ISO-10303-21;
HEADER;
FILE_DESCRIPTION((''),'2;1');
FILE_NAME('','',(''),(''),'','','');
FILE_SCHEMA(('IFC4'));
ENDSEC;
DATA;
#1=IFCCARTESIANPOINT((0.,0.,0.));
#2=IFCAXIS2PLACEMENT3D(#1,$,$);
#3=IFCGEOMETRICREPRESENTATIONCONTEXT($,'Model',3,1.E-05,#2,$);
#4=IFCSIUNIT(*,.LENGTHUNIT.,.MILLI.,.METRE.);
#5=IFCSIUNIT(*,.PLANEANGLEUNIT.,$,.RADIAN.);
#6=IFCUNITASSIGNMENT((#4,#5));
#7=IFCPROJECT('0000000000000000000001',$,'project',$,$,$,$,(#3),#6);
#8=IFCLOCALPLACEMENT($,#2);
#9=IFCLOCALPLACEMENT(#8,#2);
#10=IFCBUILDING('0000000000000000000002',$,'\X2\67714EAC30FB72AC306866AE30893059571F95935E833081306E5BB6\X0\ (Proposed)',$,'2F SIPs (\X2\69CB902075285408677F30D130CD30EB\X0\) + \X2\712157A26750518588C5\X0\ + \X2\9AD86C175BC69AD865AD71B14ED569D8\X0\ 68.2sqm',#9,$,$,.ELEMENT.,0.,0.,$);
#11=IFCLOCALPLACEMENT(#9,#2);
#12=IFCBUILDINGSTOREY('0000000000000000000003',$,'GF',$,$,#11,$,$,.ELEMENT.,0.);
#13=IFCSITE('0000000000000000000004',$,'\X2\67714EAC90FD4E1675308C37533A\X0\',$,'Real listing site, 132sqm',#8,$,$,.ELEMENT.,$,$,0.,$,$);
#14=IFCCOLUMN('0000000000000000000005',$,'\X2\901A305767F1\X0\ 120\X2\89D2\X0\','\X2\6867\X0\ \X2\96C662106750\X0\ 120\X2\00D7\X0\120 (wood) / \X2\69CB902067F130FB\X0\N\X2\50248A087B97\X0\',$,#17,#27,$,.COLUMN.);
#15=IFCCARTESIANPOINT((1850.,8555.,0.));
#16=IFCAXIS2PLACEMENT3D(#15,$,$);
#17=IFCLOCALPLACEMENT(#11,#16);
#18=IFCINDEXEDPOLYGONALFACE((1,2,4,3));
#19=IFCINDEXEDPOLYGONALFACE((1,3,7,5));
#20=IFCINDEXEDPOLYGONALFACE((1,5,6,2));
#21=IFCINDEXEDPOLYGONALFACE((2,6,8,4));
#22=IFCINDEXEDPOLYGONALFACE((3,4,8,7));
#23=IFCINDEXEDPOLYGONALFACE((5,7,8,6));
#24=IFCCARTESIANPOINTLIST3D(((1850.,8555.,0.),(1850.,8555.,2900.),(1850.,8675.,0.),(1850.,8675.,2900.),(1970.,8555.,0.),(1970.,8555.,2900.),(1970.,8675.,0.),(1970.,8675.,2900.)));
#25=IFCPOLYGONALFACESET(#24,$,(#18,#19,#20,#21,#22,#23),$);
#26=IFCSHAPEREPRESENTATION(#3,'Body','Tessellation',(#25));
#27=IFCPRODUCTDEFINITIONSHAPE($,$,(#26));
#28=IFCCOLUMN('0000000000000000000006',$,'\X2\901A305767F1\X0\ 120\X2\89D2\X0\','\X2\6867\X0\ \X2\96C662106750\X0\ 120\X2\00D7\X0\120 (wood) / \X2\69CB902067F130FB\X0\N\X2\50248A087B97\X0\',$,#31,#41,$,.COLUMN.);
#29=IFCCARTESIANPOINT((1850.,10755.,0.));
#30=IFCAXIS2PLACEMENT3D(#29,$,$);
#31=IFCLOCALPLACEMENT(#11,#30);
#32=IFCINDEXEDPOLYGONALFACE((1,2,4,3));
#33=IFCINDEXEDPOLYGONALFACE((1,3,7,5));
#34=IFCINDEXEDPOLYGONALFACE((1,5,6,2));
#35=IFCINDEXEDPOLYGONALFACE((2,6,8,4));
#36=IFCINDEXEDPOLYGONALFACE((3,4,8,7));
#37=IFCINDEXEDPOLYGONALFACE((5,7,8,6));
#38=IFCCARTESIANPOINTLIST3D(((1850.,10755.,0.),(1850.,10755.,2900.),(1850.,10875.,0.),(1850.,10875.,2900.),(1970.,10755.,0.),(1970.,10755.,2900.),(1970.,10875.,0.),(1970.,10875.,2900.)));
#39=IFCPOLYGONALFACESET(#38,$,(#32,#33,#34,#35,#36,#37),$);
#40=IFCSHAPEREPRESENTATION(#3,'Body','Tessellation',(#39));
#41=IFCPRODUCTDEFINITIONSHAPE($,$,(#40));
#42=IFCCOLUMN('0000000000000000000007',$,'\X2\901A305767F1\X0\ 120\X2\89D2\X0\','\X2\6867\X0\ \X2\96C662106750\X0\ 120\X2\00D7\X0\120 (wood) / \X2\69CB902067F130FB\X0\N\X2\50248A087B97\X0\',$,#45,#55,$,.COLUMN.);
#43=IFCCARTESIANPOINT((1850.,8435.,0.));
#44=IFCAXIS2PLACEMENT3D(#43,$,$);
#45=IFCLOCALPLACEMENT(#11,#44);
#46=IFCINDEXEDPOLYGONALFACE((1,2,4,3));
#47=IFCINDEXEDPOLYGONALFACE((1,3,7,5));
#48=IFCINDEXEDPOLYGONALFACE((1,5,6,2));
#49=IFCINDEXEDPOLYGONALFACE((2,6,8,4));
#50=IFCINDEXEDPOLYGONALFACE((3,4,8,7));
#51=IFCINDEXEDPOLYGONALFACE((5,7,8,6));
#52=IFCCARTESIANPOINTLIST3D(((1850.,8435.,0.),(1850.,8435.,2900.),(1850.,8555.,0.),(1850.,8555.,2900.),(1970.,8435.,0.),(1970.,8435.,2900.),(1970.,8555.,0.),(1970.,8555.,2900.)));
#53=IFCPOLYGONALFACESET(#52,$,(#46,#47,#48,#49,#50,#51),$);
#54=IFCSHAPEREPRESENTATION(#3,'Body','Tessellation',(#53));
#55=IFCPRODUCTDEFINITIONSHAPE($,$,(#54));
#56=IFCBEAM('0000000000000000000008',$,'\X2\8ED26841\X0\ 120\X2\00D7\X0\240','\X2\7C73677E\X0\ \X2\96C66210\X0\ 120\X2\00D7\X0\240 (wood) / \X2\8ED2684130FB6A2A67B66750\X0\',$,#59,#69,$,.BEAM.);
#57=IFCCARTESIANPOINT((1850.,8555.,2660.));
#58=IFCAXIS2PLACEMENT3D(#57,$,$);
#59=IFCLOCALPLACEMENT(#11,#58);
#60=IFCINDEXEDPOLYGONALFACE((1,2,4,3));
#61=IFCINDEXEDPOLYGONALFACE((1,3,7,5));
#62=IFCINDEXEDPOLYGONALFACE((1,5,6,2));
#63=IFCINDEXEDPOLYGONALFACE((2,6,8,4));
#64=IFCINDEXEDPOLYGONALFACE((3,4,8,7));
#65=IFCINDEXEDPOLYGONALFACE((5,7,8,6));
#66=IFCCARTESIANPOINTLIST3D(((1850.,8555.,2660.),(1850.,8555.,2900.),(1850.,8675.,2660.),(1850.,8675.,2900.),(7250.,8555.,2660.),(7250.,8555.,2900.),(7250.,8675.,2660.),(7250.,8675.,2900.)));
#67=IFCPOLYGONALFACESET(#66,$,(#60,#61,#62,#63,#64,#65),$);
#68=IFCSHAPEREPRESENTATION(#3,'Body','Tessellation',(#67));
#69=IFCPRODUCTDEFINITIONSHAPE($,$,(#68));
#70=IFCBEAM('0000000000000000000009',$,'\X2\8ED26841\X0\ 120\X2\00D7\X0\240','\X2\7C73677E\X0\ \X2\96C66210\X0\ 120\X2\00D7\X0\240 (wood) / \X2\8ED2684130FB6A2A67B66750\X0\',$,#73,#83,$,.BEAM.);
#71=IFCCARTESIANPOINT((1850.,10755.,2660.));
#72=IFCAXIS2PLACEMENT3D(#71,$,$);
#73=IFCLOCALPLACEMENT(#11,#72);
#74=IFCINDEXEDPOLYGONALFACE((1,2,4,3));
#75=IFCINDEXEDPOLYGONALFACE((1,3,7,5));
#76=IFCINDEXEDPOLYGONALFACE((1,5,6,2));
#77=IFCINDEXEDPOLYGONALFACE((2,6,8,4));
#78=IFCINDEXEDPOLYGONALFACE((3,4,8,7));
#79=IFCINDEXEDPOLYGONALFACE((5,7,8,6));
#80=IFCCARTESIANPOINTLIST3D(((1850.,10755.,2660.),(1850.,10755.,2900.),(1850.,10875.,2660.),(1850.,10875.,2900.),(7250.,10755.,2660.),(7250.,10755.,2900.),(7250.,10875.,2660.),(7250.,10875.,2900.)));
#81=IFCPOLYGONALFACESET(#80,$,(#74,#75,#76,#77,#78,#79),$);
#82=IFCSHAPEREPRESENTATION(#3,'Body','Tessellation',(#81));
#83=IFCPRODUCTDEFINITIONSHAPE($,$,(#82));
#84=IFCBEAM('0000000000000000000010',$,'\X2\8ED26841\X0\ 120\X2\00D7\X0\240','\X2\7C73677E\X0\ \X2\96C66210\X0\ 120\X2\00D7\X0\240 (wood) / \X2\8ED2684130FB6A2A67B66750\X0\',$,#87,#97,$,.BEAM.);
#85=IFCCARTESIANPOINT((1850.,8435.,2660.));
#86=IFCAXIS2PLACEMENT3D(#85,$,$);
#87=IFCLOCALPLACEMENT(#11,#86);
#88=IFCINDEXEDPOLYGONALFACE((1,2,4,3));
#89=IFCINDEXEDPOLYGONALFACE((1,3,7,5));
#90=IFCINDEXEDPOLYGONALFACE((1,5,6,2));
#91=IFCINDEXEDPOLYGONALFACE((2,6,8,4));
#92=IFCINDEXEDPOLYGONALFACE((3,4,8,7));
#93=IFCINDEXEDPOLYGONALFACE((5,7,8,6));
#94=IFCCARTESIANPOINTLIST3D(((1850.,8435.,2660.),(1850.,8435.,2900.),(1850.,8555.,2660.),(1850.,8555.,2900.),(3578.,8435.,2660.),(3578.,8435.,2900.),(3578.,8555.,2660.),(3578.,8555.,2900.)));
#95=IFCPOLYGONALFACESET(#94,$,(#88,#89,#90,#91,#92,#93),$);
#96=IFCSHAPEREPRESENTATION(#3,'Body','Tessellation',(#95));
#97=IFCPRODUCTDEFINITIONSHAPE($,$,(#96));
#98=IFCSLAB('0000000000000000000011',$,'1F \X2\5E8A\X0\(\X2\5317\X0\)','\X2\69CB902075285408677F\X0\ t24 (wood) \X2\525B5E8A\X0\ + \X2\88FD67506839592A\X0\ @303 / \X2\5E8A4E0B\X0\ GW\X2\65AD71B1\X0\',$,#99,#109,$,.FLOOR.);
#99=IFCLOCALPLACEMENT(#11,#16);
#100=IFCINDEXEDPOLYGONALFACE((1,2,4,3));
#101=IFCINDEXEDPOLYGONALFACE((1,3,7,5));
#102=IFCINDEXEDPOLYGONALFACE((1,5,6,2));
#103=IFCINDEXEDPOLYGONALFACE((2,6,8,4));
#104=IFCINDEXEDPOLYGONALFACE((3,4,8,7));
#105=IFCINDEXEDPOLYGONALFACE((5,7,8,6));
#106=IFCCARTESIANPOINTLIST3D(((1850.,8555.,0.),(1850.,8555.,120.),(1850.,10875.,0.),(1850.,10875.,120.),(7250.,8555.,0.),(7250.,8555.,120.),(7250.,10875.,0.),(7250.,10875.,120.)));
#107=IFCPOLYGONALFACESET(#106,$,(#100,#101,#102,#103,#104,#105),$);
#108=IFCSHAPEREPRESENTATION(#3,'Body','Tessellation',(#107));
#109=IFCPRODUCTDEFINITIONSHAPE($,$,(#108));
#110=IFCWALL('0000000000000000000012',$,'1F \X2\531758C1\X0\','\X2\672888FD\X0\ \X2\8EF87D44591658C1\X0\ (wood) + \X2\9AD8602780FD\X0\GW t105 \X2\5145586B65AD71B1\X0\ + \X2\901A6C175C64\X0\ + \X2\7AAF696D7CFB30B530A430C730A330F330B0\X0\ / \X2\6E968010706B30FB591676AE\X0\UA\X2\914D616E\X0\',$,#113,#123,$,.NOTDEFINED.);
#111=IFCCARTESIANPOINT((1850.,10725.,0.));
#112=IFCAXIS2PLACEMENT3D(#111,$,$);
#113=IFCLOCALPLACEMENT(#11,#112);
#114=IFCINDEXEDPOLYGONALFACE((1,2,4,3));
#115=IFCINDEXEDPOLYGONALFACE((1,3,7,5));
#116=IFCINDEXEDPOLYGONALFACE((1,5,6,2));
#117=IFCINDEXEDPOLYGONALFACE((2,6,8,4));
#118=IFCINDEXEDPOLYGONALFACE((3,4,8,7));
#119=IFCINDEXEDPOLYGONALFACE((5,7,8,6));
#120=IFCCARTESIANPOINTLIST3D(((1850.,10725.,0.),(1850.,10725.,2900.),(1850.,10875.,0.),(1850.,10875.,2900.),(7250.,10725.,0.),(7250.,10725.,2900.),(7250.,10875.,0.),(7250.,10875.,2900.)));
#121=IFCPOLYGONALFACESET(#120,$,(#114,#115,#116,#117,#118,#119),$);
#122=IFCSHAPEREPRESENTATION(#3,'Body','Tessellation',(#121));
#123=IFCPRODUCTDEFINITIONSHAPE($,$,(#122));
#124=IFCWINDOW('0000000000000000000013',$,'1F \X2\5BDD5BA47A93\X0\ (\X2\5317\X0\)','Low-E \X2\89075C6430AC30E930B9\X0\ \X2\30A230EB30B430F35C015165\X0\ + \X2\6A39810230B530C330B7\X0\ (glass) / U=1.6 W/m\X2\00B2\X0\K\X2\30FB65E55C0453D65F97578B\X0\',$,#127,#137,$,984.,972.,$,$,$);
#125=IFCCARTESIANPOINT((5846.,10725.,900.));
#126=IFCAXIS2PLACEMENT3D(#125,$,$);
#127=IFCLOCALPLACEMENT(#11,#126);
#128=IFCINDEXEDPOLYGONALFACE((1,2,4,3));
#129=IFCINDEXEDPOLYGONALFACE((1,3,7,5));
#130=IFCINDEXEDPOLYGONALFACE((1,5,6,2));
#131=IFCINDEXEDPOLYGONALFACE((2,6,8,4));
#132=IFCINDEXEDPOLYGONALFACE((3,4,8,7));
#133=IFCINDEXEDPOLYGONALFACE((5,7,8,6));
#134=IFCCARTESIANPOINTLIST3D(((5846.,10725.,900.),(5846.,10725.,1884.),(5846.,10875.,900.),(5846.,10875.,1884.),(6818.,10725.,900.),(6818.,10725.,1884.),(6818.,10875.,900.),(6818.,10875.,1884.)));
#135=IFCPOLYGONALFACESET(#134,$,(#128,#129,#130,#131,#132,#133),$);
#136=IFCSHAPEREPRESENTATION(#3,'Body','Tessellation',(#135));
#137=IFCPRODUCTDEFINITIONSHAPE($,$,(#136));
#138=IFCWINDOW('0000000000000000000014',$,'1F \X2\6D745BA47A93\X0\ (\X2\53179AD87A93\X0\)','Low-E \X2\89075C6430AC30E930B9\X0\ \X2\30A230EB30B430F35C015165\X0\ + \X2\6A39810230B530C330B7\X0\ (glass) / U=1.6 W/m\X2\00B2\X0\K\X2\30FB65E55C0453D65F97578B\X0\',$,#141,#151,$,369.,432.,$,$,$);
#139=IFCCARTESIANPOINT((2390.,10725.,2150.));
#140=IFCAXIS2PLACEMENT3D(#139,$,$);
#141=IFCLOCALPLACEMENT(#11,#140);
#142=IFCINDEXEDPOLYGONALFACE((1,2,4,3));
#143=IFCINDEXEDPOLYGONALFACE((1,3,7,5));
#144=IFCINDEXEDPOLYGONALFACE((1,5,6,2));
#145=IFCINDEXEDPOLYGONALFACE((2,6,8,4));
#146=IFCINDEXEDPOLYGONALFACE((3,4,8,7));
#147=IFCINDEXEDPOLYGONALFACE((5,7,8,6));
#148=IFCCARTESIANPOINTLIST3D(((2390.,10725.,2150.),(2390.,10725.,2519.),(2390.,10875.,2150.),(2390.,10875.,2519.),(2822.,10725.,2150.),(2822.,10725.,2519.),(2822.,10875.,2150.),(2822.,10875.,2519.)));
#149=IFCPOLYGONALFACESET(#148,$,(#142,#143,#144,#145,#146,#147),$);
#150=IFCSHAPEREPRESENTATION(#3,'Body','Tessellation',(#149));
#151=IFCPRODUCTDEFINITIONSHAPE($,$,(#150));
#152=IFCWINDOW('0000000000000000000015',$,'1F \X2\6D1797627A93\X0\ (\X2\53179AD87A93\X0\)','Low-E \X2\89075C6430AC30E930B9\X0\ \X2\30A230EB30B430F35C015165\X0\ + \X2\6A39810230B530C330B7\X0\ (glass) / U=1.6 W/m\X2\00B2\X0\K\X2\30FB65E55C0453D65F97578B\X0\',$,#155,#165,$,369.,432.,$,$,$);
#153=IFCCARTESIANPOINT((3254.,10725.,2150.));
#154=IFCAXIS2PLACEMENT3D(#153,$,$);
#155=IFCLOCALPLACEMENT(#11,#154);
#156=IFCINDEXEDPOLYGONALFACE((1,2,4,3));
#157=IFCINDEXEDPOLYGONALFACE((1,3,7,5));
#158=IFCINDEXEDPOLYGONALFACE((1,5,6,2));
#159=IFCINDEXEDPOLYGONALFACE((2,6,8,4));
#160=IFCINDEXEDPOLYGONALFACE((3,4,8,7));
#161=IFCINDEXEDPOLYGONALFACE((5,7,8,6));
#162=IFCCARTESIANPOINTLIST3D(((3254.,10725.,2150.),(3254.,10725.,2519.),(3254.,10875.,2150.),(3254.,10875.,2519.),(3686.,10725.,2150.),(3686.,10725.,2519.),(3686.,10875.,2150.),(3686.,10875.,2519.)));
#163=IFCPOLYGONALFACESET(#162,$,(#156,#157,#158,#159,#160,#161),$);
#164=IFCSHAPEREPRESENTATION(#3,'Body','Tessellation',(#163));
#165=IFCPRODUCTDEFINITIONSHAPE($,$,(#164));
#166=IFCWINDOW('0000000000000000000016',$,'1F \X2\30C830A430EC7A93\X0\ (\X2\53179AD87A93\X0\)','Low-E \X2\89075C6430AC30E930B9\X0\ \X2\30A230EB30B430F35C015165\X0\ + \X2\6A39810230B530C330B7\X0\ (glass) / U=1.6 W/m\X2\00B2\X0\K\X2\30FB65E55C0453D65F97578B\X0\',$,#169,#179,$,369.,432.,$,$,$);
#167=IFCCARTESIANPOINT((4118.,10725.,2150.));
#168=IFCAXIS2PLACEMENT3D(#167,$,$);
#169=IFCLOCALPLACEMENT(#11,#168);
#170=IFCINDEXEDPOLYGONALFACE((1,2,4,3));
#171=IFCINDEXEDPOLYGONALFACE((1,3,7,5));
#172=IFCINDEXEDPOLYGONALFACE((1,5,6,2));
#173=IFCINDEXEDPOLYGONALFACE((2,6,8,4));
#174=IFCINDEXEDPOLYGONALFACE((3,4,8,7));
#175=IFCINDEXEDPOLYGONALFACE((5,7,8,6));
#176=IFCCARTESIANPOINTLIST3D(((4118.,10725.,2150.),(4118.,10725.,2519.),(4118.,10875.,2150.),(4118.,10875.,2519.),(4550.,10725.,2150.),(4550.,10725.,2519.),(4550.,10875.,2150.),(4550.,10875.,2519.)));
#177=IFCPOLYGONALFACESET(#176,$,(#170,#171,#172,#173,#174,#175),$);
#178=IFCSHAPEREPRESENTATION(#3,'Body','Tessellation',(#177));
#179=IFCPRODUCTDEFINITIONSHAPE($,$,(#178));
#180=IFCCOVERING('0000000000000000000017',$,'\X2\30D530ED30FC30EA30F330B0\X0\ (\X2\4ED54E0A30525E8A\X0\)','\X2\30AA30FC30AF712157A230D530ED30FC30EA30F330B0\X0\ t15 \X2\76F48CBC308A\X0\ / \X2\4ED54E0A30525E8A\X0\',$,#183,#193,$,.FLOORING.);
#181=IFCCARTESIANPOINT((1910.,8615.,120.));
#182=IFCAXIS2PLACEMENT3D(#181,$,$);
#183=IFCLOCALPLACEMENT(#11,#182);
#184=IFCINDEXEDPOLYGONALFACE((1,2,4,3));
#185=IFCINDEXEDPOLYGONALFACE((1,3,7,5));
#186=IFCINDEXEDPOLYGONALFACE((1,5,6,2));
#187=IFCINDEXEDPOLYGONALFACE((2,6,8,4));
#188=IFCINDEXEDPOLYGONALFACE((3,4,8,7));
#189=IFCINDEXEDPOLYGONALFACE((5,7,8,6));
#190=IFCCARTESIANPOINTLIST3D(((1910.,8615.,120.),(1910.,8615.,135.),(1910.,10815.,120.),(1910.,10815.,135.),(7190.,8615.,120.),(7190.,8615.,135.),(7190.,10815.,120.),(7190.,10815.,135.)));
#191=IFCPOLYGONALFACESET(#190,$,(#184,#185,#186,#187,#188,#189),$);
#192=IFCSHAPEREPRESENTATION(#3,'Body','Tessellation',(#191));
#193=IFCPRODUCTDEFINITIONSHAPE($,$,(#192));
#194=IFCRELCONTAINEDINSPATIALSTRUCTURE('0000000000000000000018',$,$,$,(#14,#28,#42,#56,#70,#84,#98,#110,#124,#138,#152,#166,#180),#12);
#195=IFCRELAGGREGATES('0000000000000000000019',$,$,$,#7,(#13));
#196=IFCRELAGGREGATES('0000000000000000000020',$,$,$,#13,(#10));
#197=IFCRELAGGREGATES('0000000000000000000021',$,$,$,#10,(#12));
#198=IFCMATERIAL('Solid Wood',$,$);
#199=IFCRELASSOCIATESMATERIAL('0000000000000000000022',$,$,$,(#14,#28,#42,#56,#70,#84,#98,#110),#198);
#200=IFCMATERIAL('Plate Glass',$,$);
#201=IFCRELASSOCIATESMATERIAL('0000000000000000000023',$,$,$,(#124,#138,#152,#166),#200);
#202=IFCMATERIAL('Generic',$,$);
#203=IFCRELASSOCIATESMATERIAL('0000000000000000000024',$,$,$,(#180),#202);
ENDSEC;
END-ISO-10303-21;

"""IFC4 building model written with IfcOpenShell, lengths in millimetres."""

from ifc_helpers import new_model, si_unit, frame, frame_2d, origin, place, context, project, spatial, rectangle, extrude, material, element, fill, save


model = new_model("IFC4")

# Units and contexts
model_context = context("Model", 3, precision=1e-05, world=origin())
ifc_project = project(units=[si_unit("LENGTHUNIT", "METRE", prefix="MILLI"), si_unit("PLANEANGLEUNIT", "RADIAN")], contexts=[model_context])

# Site, building, storey
site_placement = place(None, origin())
site = spatial("IfcSite", under=ifc_project, at=site_placement, Name="東京都世田谷区", ObjectType="Real listing site, 132sqm", CompositionType="ELEMENT", RefElevation=0.0)
building_placement = place(site_placement, origin())
building = spatial("IfcBuilding", under=site, at=building_placement, Name="東京・犬と暮らす土間広めの家 (Proposed)", ObjectType="2F SIPs (構造用合板パネル) + 無垢材内装 + 高気密高断熱仕様 68.2sqm", CompositionType="ELEMENT", ElevationOfRefHeight=0.0, ElevationOfTerrain=0.0)
storey_placement = place(building_placement, origin())
storey = spatial("IfcBuildingStorey", under=building, at=storey_placement, Name="GF", CompositionType="ELEMENT", Elevation=0.0)

# Columns
ifc_material_1 = material(Name="Solid Wood")
column_1_placement = place(storey_placement, frame((1850.0, 8555.0, 0.0)))
element("IfcColumn", 1, at=column_1_placement, inside=storey, material=ifc_material_1, Name="通し柱 120角", Description="桧 集成材 120×120 (wood) / 構造柱・N値計算", PredefinedType="COLUMN", context=model_context, shape_type="SweptSolid", body=[
    extrude(rectangle(XDim=120.0, YDim=120.0, at=frame_2d((60.0, 60.0))), frame((1850.0, 8555.0, 0.0)), (0.0, 0.0, 1.0), 2900.0),
])
column_2_placement = place(storey_placement, frame((1850.0, 10755.0, 0.0)))
element("IfcColumn", 2, at=column_2_placement, inside=storey, material=ifc_material_1, Name="通し柱 120角", Description="桧 集成材 120×120 (wood) / 構造柱・N値計算", PredefinedType="COLUMN", context=model_context, shape_type="SweptSolid", body=[
    extrude(rectangle(XDim=120.0, YDim=120.0, at=frame_2d((60.0, 60.0))), frame((1850.0, 10755.0, 0.0)), (0.0, 0.0, 1.0), 2900.0),
])
column_3_placement = place(storey_placement, frame((1850.0, 8435.0, 0.0)))
element("IfcColumn", 3, at=column_3_placement, inside=storey, material=ifc_material_1, Name="通し柱 120角", Description="桧 集成材 120×120 (wood) / 構造柱・N値計算", PredefinedType="COLUMN", context=model_context, shape_type="SweptSolid", body=[
    extrude(rectangle(XDim=120.0, YDim=120.0, at=frame_2d((60.0, 60.0))), frame((1850.0, 8435.0, 0.0)), (0.0, 0.0, 1.0), 2900.0),
])

# Beams
beam_1_placement = place(storey_placement, frame((1850.0, 8555.0, 2660.0)))
element("IfcBeam", 4, at=beam_1_placement, inside=storey, material=ifc_material_1, Name="軒桁 120×240", Description="米松 集成 120×240 (wood) / 軒桁・横架材", PredefinedType="BEAM", context=model_context, shape_type="SweptSolid", body=[
    extrude(rectangle(XDim=5400.0, YDim=120.0, at=frame_2d((2700.0, 60.0))), frame((1850.0, 8555.0, 2660.0)), (0.0, 0.0, 1.0), 240.0),
])
beam_2_placement = place(storey_placement, frame((1850.0, 10755.0, 2660.0)))
element("IfcBeam", 5, at=beam_2_placement, inside=storey, material=ifc_material_1, Name="軒桁 120×240", Description="米松 集成 120×240 (wood) / 軒桁・横架材", PredefinedType="BEAM", context=model_context, shape_type="SweptSolid", body=[
    extrude(rectangle(XDim=5400.0, YDim=120.0, at=frame_2d((2700.0, 60.0))), frame((1850.0, 10755.0, 2660.0)), (0.0, 0.0, 1.0), 240.0),
])
beam_3_placement = place(storey_placement, frame((1850.0, 8435.0, 2660.0)))
element("IfcBeam", 6, at=beam_3_placement, inside=storey, material=ifc_material_1, Name="軒桁 120×240", Description="米松 集成 120×240 (wood) / 軒桁・横架材", PredefinedType="BEAM", context=model_context, shape_type="SweptSolid", body=[
    extrude(rectangle(XDim=1728.0, YDim=120.0, at=frame_2d((864.0, 60.0))), frame((1850.0, 8435.0, 2660.0)), (0.0, 0.0, 1.0), 240.0),
])

# Slab
slab_placement = place(storey_placement, frame((1850.0, 8555.0, 0.0)))
element("IfcSlab", 7, at=slab_placement, inside=storey, material=ifc_material_1, Name="1F 床(北)", Description="構造用合板 t24 (wood) 剛床 + 製材根太 @303 / 床下 GW断熱", PredefinedType="FLOOR", context=model_context, shape_type="SweptSolid", body=[
    extrude(rectangle(XDim=5400.0, YDim=2320.0, at=frame_2d((2700.0, 1160.0))), frame((1850.0, 8555.0, 0.0)), (0.0, 0.0, 1.0), 120.0),
])

# Wall, openings, windows
wall_1_placement = place(storey_placement, frame((1850.0, 10725.0, 0.0)))
wall_1 = element("IfcWall", 8, at=wall_1_placement, inside=storey, material=ifc_material_1, Name="1F 北壁", Description="木製 軸組外壁 (wood) + 高性能GW t105 充填断熱 + 通気層 + 窯業系サイディング / 準耐火・外皮UA配慮", PredefinedType="NOTDEFINED", context=model_context, shape_type="SweptSolid", body=[
    extrude(rectangle(XDim=5400.0, YDim=150.0, at=frame_2d((2700.0, 75.0))), frame((1850.0, 10725.0, 0.0)), (0.0, 0.0, 1.0), 2900.0),
])
opening_1_placement = place(storey_placement, frame((5846.0, 10725.0, 900.0)))
opening_1 = element("IfcOpeningElement", 9, at=opening_1_placement, cuts=wall_1, PredefinedType="NOTDEFINED", context=model_context, shape_type="SweptSolid", body=[
    extrude(rectangle(XDim=972.0, YDim=150.0, at=frame_2d((486.0, 75.0))), frame((5846.0, 10725.0, 900.0)), (0.0, 0.0, 1.0), 984.0),
])
opening_2_placement = place(storey_placement, frame((2390.0, 10725.0, 2150.0)))
opening_2 = element("IfcOpeningElement", 10, at=opening_2_placement, cuts=wall_1, PredefinedType="NOTDEFINED", context=model_context, shape_type="SweptSolid", body=[
    extrude(rectangle(XDim=432.0, YDim=150.0, at=frame_2d((216.0, 75.0))), frame((2390.0, 10725.0, 2150.0)), (0.0, 0.0, 1.0), 369.0),
])
opening_3_placement = place(storey_placement, frame((3254.0, 10725.0, 2150.0)))
opening_3 = element("IfcOpeningElement", 11, at=opening_3_placement, cuts=wall_1, PredefinedType="NOTDEFINED", context=model_context, shape_type="SweptSolid", body=[
    extrude(rectangle(XDim=432.0, YDim=150.0, at=frame_2d((216.0, 75.0))), frame((3254.0, 10725.0, 2150.0)), (0.0, 0.0, 1.0), 369.0),
])
opening_4_placement = place(storey_placement, frame((4118.0, 10725.0, 2150.0)))
opening_4 = element("IfcOpeningElement", 12, at=opening_4_placement, cuts=wall_1, PredefinedType="NOTDEFINED", context=model_context, shape_type="SweptSolid", body=[
    extrude(rectangle(XDim=432.0, YDim=150.0, at=frame_2d((216.0, 75.0))), frame((4118.0, 10725.0, 2150.0)), (0.0, 0.0, 1.0), 369.0),
])
ifc_material_2 = material(Name="Plate Glass")
window_1_placement = place(storey_placement, frame((5846.0, 10725.0, 900.0)))
window_1 = element("IfcWindow", 13, at=window_1_placement, inside=storey, material=ifc_material_2, Name="1F 寝室窓 (北)", Description="Low-E 複層ガラス アルゴン封入 + 樹脂サッシ (glass) / U=1.6 W/m²K・日射取得型", OverallHeight=984.0, OverallWidth=972.0, context=model_context, shape_type="SweptSolid", body=[
    extrude(rectangle(XDim=972.0, YDim=150.0, at=frame_2d((486.0, 75.0))), frame((5846.0, 10725.0, 900.0)), (0.0, 0.0, 1.0), 984.0),
])
fill(opening_1, window_1)
window_2_placement = place(storey_placement, frame((2390.0, 10725.0, 2150.0)))
window_2 = element("IfcWindow", 14, at=window_2_placement, inside=storey, material=ifc_material_2, Name="1F 浴室窓 (北高窓)", Description="Low-E 複層ガラス アルゴン封入 + 樹脂サッシ (glass) / U=1.6 W/m²K・日射取得型", OverallHeight=369.0, OverallWidth=432.0, context=model_context, shape_type="SweptSolid", body=[
    extrude(rectangle(XDim=432.0, YDim=150.0, at=frame_2d((216.0, 75.0))), frame((2390.0, 10725.0, 2150.0)), (0.0, 0.0, 1.0), 369.0),
])
fill(opening_2, window_2)
window_3_placement = place(storey_placement, frame((3254.0, 10725.0, 2150.0)))
window_3 = element("IfcWindow", 15, at=window_3_placement, inside=storey, material=ifc_material_2, Name="1F 洗面窓 (北高窓)", Description="Low-E 複層ガラス アルゴン封入 + 樹脂サッシ (glass) / U=1.6 W/m²K・日射取得型", OverallHeight=369.0, OverallWidth=432.0, context=model_context, shape_type="SweptSolid", body=[
    extrude(rectangle(XDim=432.0, YDim=150.0, at=frame_2d((216.0, 75.0))), frame((3254.0, 10725.0, 2150.0)), (0.0, 0.0, 1.0), 369.0),
])
fill(opening_3, window_3)
window_4_placement = place(storey_placement, frame((4118.0, 10725.0, 2150.0)))
window_4 = element("IfcWindow", 16, at=window_4_placement, inside=storey, material=ifc_material_2, Name="1F トイレ窓 (北高窓)", Description="Low-E 複層ガラス アルゴン封入 + 樹脂サッシ (glass) / U=1.6 W/m²K・日射取得型", OverallHeight=369.0, OverallWidth=432.0, context=model_context, shape_type="SweptSolid", body=[
    extrude(rectangle(XDim=432.0, YDim=150.0, at=frame_2d((216.0, 75.0))), frame((4118.0, 10725.0, 2150.0)), (0.0, 0.0, 1.0), 369.0),
])
fill(opening_4, window_4)

# Covering
ifc_material_3 = material(Name="Generic")
covering_1_placement = place(storey_placement, frame((1910.0, 8615.0, 120.0)))
element("IfcCovering", 17, at=covering_1_placement, inside=storey, material=ifc_material_3, Name="フローリング (仕上げ床)", Description="オーク無垢フローリング t15 直貼り / 仕上げ床", PredefinedType="FLOORING", context=model_context, shape_type="SweptSolid", body=[
    extrude(rectangle(XDim=5280.0, YDim=2200.0, at=frame_2d((2640.0, 1100.0))), frame((1910.0, 8615.0, 120.0)), (0.0, 0.0, 1.0), 15.0),
])

save(model, "model.ifc")
